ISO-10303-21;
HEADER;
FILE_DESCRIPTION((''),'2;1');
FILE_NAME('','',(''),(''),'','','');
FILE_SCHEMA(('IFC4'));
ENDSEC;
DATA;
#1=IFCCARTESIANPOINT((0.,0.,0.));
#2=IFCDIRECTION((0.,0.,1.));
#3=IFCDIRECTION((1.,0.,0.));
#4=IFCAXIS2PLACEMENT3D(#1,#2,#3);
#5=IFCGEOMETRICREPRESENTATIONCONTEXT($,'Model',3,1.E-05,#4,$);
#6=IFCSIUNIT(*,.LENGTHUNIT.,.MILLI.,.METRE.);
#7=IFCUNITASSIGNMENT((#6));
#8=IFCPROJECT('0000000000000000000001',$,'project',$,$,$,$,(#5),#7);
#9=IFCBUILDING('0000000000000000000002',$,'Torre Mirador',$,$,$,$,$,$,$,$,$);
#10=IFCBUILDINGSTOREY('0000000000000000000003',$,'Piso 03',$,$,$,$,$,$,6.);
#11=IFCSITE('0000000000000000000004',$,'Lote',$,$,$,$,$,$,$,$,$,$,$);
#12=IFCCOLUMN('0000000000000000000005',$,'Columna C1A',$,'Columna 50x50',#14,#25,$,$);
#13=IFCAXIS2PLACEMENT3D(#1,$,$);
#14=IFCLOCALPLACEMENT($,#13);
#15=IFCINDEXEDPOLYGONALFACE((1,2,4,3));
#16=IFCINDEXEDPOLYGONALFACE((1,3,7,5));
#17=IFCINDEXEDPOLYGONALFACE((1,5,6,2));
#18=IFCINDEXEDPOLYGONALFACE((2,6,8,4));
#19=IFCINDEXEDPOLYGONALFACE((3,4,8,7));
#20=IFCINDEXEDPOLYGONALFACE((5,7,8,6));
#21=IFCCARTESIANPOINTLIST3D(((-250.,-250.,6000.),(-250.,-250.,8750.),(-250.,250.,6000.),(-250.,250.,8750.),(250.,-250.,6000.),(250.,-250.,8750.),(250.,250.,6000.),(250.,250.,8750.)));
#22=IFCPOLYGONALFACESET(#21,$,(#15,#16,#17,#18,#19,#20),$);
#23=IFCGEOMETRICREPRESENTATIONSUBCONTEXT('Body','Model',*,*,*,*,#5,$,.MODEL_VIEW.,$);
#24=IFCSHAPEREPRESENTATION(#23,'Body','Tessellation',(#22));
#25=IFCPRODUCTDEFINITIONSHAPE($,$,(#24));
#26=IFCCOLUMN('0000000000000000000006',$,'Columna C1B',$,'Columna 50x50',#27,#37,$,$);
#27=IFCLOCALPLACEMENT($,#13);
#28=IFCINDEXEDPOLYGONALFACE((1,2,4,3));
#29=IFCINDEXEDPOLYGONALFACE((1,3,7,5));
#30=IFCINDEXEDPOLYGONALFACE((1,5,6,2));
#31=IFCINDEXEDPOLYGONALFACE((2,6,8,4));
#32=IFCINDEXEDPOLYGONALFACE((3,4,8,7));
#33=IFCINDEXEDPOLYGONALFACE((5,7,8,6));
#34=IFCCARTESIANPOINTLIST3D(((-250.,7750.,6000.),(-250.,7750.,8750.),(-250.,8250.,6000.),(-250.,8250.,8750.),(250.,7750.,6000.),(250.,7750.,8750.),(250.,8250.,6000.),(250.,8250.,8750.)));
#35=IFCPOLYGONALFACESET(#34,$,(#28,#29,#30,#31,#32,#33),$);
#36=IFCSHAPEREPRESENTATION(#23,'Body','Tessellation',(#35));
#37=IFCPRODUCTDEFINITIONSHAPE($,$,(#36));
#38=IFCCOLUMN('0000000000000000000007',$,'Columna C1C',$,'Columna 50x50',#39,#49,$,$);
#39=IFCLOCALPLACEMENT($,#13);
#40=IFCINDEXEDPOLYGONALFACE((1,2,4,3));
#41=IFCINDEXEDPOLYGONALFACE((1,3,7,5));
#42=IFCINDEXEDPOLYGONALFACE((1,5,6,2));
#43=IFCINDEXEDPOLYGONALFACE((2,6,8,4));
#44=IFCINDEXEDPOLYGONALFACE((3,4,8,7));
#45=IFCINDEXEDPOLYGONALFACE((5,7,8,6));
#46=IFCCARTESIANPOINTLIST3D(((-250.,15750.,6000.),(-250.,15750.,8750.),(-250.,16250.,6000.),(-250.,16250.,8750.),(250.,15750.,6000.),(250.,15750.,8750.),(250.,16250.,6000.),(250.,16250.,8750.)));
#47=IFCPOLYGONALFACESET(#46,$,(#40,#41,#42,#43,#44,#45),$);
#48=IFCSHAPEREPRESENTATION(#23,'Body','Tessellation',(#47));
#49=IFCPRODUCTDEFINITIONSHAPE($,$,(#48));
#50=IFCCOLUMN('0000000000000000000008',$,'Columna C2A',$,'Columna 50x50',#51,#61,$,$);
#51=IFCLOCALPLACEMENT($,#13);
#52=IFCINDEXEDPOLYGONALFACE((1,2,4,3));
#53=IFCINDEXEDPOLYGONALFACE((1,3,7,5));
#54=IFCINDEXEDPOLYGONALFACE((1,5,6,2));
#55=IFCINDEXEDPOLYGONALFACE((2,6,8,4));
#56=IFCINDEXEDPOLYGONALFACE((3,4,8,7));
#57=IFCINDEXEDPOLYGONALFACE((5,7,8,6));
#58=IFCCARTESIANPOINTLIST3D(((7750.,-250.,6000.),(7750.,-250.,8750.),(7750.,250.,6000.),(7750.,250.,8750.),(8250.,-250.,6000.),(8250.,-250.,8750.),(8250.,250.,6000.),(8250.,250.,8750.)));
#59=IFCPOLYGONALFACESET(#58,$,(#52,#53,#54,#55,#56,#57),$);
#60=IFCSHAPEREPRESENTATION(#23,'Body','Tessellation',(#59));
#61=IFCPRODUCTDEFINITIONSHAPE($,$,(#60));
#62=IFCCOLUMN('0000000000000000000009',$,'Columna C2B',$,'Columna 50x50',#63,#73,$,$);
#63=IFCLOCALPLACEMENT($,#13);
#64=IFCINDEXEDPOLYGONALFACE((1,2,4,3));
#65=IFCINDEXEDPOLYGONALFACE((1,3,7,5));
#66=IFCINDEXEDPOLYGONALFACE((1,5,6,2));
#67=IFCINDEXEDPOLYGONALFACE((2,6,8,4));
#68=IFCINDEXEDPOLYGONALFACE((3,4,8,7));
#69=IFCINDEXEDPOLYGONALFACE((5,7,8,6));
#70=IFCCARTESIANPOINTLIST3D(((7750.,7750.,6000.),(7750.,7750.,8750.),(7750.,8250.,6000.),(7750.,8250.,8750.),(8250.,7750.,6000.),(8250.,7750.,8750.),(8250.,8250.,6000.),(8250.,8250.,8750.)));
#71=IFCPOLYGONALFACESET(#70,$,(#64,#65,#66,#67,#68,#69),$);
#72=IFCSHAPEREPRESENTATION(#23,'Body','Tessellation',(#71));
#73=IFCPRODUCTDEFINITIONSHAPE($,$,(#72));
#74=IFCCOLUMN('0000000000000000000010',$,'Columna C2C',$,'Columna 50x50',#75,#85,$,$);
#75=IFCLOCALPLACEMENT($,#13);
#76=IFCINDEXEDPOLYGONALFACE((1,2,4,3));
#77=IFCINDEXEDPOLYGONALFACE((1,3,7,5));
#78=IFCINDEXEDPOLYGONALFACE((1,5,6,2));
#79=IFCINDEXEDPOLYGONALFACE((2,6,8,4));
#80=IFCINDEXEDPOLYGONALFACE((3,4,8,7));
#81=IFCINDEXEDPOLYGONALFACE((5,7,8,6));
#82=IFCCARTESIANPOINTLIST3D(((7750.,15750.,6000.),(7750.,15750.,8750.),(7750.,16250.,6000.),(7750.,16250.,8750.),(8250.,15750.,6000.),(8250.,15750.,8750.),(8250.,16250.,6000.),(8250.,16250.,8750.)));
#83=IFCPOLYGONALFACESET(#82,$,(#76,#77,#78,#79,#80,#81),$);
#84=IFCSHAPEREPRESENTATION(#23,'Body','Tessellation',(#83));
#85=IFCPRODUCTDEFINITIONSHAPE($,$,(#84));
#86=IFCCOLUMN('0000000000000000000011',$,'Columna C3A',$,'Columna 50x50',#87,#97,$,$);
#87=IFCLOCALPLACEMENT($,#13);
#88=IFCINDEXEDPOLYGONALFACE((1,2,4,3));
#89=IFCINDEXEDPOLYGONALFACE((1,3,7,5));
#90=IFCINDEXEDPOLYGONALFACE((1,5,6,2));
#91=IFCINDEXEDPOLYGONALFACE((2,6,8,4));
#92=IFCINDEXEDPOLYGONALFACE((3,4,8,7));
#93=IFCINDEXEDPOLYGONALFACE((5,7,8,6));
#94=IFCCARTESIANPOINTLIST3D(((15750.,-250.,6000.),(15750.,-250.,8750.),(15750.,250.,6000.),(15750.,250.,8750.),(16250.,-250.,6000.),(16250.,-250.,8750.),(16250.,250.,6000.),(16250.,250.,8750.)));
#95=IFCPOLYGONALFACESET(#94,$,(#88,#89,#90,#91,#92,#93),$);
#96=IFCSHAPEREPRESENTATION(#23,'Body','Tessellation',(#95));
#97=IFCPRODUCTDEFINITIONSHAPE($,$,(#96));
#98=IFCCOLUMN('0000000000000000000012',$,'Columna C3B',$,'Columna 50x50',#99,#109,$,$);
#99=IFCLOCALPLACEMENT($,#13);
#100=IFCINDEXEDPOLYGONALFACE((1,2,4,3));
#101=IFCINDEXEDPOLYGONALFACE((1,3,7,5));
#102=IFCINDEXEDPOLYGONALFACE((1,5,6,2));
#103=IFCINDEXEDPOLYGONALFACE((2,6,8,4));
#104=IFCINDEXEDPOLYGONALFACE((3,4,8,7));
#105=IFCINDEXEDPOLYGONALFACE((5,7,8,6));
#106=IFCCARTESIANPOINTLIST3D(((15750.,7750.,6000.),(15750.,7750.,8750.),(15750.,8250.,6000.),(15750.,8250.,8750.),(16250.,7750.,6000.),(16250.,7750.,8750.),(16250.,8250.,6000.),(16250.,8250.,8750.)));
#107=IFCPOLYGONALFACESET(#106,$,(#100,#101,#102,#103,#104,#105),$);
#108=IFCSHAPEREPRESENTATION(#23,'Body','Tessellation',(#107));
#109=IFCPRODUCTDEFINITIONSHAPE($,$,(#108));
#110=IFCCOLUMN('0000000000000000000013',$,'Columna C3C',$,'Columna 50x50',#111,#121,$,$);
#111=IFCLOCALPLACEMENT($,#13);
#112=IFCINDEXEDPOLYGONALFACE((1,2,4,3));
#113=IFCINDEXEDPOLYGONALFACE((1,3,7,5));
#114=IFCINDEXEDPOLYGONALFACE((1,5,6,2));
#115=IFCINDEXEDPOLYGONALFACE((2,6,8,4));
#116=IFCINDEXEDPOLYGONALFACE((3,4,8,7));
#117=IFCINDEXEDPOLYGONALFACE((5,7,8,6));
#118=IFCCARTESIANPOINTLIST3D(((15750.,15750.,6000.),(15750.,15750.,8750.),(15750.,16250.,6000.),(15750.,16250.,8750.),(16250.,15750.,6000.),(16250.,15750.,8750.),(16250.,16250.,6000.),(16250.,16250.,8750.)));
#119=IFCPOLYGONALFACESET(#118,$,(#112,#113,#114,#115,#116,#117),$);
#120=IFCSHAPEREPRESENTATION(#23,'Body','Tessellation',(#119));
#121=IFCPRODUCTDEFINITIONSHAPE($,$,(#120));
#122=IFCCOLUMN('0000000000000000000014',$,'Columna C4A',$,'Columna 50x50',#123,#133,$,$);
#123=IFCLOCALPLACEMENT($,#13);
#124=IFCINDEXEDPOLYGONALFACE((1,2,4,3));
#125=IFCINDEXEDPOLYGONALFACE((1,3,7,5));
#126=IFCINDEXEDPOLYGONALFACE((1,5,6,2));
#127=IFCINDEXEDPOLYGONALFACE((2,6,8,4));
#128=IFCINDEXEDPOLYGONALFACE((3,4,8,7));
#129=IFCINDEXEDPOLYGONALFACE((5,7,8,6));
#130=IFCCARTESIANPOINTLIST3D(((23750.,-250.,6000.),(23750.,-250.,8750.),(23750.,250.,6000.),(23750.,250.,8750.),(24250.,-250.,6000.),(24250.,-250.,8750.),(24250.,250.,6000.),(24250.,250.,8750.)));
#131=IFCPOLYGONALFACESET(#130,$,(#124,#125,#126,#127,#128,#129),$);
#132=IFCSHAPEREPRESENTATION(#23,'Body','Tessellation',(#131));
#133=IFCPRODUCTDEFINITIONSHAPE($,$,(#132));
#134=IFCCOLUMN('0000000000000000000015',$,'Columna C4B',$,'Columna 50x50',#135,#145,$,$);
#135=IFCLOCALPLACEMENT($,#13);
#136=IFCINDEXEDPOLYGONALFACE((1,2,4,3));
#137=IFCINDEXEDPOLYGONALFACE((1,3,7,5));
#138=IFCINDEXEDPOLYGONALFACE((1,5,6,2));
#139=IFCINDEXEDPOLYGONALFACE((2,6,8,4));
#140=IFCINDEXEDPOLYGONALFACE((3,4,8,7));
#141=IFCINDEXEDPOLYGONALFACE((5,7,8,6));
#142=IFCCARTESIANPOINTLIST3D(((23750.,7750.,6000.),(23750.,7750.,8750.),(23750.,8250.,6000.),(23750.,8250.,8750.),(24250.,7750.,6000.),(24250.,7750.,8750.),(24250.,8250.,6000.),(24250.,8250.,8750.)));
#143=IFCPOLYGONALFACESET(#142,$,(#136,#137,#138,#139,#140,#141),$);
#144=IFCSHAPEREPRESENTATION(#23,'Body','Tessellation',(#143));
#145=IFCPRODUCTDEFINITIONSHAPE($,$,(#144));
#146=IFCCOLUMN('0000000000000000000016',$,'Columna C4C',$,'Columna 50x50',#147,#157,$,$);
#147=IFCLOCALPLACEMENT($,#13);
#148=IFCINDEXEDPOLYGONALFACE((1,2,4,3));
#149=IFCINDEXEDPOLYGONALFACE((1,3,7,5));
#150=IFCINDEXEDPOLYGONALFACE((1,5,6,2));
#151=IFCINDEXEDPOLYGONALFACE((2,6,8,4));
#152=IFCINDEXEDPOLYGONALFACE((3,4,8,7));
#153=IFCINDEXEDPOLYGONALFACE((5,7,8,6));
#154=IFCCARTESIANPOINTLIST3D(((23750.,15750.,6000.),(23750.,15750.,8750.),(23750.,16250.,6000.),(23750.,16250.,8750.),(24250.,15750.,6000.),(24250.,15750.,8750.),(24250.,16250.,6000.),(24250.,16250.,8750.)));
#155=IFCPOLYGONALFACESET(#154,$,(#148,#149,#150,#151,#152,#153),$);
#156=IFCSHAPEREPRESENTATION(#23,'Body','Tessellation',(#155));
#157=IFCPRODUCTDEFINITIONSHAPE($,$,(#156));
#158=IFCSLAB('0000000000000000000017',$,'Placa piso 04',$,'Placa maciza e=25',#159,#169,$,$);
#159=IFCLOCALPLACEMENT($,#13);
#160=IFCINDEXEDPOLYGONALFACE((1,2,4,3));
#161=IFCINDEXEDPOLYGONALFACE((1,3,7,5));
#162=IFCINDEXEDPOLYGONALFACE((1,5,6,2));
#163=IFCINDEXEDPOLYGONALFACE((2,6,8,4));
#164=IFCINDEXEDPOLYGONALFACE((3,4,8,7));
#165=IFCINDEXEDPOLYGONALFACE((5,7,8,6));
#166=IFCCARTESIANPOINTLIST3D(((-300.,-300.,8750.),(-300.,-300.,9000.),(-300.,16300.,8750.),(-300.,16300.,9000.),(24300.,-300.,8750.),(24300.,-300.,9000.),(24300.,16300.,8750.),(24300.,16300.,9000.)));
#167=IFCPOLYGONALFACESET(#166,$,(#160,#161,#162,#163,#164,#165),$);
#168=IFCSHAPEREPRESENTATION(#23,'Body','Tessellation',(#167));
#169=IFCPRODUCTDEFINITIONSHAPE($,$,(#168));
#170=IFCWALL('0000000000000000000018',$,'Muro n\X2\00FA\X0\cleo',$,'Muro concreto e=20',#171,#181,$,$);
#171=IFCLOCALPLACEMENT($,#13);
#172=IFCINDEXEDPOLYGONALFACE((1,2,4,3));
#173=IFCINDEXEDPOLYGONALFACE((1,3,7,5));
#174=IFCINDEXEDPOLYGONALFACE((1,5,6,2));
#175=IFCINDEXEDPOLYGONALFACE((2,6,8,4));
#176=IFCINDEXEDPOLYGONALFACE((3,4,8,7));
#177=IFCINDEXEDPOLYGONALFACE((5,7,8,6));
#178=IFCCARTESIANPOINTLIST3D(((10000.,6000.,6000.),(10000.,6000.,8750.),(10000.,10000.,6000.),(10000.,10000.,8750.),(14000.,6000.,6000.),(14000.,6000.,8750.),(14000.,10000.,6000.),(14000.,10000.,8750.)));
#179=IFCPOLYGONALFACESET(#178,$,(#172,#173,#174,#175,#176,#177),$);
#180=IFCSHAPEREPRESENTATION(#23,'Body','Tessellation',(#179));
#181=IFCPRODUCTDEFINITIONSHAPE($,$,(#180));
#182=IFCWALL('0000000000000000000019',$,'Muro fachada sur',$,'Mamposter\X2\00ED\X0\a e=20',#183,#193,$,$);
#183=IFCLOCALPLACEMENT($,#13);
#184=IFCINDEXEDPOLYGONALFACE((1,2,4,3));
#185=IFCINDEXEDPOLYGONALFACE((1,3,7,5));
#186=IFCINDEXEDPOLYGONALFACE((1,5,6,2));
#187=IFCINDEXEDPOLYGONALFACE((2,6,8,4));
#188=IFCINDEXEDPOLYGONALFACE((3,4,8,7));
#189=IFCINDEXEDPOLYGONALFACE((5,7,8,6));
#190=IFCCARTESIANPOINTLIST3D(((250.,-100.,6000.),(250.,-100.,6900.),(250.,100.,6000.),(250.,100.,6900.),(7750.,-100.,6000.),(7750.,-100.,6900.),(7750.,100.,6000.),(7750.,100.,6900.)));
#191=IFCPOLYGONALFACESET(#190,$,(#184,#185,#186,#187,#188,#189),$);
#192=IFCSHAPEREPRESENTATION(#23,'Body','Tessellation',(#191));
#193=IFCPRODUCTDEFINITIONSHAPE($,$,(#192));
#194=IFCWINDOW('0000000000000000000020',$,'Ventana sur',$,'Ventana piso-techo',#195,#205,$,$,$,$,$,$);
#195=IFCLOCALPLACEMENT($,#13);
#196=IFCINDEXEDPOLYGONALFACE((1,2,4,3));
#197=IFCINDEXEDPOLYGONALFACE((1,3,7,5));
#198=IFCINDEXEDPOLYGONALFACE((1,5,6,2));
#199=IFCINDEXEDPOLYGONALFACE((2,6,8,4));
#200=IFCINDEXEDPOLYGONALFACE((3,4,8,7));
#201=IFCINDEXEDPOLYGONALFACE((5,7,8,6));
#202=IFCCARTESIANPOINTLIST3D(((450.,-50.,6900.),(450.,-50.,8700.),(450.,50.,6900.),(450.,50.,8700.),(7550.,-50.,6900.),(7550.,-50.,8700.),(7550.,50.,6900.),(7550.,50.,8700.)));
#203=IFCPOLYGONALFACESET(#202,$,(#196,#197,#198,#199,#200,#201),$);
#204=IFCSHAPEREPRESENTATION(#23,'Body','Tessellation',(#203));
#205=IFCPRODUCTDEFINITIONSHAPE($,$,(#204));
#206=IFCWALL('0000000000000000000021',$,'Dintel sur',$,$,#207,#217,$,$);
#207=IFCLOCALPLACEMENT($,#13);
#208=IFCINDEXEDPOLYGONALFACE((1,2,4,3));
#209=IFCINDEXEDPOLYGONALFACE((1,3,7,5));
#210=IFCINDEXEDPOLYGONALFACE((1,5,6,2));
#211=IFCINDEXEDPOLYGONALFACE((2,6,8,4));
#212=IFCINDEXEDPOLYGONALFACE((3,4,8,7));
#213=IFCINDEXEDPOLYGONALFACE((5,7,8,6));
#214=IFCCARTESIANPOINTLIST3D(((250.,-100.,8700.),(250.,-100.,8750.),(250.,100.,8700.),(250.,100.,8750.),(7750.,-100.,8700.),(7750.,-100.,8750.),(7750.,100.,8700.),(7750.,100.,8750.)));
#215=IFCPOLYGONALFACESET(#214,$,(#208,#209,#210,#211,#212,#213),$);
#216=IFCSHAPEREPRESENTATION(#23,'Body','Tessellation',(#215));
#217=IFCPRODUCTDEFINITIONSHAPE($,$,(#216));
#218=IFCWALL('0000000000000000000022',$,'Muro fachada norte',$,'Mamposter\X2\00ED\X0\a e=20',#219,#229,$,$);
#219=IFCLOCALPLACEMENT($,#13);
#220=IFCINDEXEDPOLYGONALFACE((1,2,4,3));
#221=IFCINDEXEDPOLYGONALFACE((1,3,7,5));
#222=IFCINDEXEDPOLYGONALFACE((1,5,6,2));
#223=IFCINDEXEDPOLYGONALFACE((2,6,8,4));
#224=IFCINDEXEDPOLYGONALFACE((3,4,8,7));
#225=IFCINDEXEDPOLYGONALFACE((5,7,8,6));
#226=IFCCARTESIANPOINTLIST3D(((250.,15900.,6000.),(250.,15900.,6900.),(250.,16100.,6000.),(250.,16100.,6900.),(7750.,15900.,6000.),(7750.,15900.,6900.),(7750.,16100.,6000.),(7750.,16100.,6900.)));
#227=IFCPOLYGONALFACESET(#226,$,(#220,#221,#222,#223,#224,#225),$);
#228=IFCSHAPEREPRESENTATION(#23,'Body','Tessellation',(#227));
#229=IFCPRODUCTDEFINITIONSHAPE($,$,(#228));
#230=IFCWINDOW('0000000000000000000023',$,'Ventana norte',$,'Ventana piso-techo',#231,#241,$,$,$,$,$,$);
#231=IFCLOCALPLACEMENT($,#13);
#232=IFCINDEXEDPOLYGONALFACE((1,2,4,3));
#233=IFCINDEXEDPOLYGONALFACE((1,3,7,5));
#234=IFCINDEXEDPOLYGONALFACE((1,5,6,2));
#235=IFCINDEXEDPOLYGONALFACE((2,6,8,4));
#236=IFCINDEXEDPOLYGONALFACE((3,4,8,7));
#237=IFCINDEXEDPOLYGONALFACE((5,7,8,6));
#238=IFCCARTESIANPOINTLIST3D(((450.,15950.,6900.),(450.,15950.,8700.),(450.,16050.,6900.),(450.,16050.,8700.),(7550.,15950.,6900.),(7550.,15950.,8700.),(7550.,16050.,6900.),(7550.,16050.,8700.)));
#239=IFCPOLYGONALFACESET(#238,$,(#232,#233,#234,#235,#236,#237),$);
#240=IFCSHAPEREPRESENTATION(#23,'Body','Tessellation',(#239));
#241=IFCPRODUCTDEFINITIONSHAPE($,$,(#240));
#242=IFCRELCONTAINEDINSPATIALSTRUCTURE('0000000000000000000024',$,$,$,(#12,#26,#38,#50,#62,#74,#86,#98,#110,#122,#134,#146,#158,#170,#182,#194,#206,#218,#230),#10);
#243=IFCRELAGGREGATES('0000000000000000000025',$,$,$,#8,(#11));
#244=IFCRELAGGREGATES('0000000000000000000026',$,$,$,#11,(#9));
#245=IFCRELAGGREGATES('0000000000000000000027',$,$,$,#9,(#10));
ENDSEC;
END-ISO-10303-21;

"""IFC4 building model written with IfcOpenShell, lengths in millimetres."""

from ifc_helpers import new_model, si_unit, frame, origin_with_axes, place, context, subcontext, project, spatial, indexed_curve, outline, extrude, element, save


model = new_model("IFC4")

# Units and contexts
model_context = context("Model", 3, precision=1e-05, world=origin_with_axes())
body_context = subcontext(model_context, "Body", "Model", "MODEL_VIEW")
ifc_project = project(units=[si_unit("LENGTHUNIT", "METRE", prefix="MILLI")], contexts=[model_context])

# Site, building, storey
site = spatial("IfcSite", under=ifc_project, Name="Lote")
building = spatial("IfcBuilding", under=site, Name="Torre Mirador")
storey = spatial("IfcBuildingStorey", under=building, Name="Piso 03", Elevation=6.0)

# Columns
for number, where, z_axis, x_axis, name in (
    (1, (-250.0, -250.0, 6000.0), (0.0, 0.0, 1.0), (1.0, 0.0, 0.0), "Columna C1A"),
    (2, (-250.0, 7750.0, 6000.0), (0.0, 0.0, 1.0), (1.0, 0.0, 0.0), "Columna C1B"),
    (3, (-250.0, 15750.0, 6000.0), (0.0, 0.0, 1.0), (1.0, 0.0, 0.0), "Columna C1C"),
    (4, (7750.0, -250.0, 6000.0), (0.0, 0.0, 1.0), (1.0, 0.0, 0.0), "Columna C2A"),
    (5, (7750.0, 7750.0, 6000.0), (0.0, 0.0, 1.0), (1.0, 0.0, 0.0), "Columna C2B"),
    (6, (7750.0, 15750.0, 6000.0), (0.0, 0.0, 1.0), (1.0, 0.0, 0.0), "Columna C2C"),
    (7, (15750.0, -250.0, 6000.0), (0.0, 0.0, 1.0), (1.0, 0.0, 0.0), "Columna C3A"),
    (8, (15750.0, 7750.0, 6000.0), (0.0, 0.0, 1.0), (1.0, 0.0, 0.0), "Columna C3B"),
    (9, (15750.0, 15750.0, 6000.0), (0.0, 0.0, 1.0), (1.0, 0.0, 0.0), "Columna C3C"),
    (10, (23750.0, -250.0, 6000.0), (0.0, 0.0, 1.0), (1.0, 0.0, 0.0), "Columna C4A"),
    (11, (23750.0, 7750.0, 6000.0), (0.0, 0.0, 1.0), (1.0, 0.0, 0.0), "Columna C4B"),
    (12, (23750.0, 15750.0, 6000.0), (0.0, 0.0, 1.0), (1.0, 0.0, 0.0), "Columna C4C"),
):
    element("IfcColumn", number, at=place(None, frame(where, z_axis=z_axis, x_axis=x_axis)), inside=storey, Name=name, ObjectType="Columna 50x50", context=body_context, shape_type="SweptSolid", body=[
        extrude(outline(indexed_curve([(0.0, 0.0), (0.0, 500.0), (500.0, 500.0), (500.0, 0.0), (0.0, 0.0)], self_intersect=False)), origin_with_axes(), (0.0, 0.0, 1.0), 2750.0),
    ])

# Slab
slab_placement = place(None, frame((-300.0, -300.0, 8750.0), z_axis=(0.0, 0.0, 1.0), x_axis=(1.0, 0.0, 0.0)))
element("IfcSlab", 13, at=slab_placement, inside=storey, Name="Placa piso 04", ObjectType="Placa maciza e=25", context=body_context, shape_type="SweptSolid", body=[
    extrude(outline(indexed_curve([(0.0, 0.0), (0.0, 16600.0), (24600.0, 16600.0), (24600.0, 0.0), (0.0, 0.0)], self_intersect=False)), origin_with_axes(), (0.0, 0.0, 1.0), 250.0),
])

# Walls
wall_1_placement = place(None, frame((10000.0, 6000.0, 6000.0), z_axis=(0.0, 0.0, 1.0), x_axis=(1.0, 0.0, 0.0)))
element("IfcWall", 14, at=wall_1_placement, inside=storey, Name="Muro núcleo", ObjectType="Muro concreto e=20", context=body_context, shape_type="SweptSolid", body=[
    extrude(outline(indexed_curve([(0.0, 0.0), (0.0, 4000.0), (4000.0, 4000.0), (4000.0, 0.0), (0.0, 0.0)], self_intersect=False)), origin_with_axes(), (0.0, 0.0, 1.0), 2750.0),
])
wall_2_placement = place(None, frame((250.0, -100.0, 6000.0), z_axis=(0.0, 0.0, 1.0), x_axis=(1.0, 0.0, 0.0)))
element("IfcWall", 15, at=wall_2_placement, inside=storey, Name="Muro fachada sur", ObjectType="Mampostería e=20", context=body_context, shape_type="SweptSolid", body=[
    extrude(outline(indexed_curve([(0.0, 0.0), (0.0, 200.0), (7500.0, 200.0), (7500.0, 0.0), (0.0, 0.0)], self_intersect=False)), origin_with_axes(), (0.0, 0.0, 1.0), 900.0),
])

# Window
window_1_placement = place(None, frame((450.0, -50.0, 6900.0), z_axis=(0.0, 0.0, 1.0), x_axis=(1.0, 0.0, 0.0)))
element("IfcWindow", 16, at=window_1_placement, inside=storey, Name="Ventana sur", ObjectType="Ventana piso-techo", context=body_context, shape_type="SweptSolid", body=[
    extrude(outline(indexed_curve([(0.0, 0.0), (0.0, 100.0), (7100.0, 100.0), (7100.0, 0.0), (0.0, 0.0)], self_intersect=False)), origin_with_axes(), (0.0, 0.0, 1.0), 1800.0),
])

# Walls
wall_3_placement = place(None, frame((250.0, -100.0, 8700.0), z_axis=(0.0, 0.0, 1.0), x_axis=(1.0, 0.0, 0.0)))
element("IfcWall", 17, at=wall_3_placement, inside=storey, Name="Dintel sur", context=body_context, shape_type="SweptSolid", body=[
    extrude(outline(indexed_curve([(0.0, 0.0), (0.0, 200.0), (7500.0, 200.0), (7500.0, 0.0), (0.0, 0.0)], self_intersect=False)), origin_with_axes(), (0.0, 0.0, 1.0), 50.0),
])
wall_4_placement = place(None, frame((250.0, 15900.0, 6000.0), z_axis=(0.0, 0.0, 1.0), x_axis=(1.0, 0.0, 0.0)))
element("IfcWall", 18, at=wall_4_placement, inside=storey, Name="Muro fachada norte", ObjectType="Mampostería e=20", context=body_context, shape_type="SweptSolid", body=[
    extrude(outline(indexed_curve([(0.0, 0.0), (0.0, 200.0), (7500.0, 200.0), (7500.0, 0.0), (0.0, 0.0)], self_intersect=False)), origin_with_axes(), (0.0, 0.0, 1.0), 900.0),
])

# Window
window_2_placement = place(None, frame((450.0, 15950.0, 6900.0), z_axis=(0.0, 0.0, 1.0), x_axis=(1.0, 0.0, 0.0)))
element("IfcWindow", 19, at=window_2_placement, inside=storey, Name="Ventana norte", ObjectType="Ventana piso-techo", context=body_context, shape_type="SweptSolid", body=[
    extrude(outline(indexed_curve([(0.0, 0.0), (0.0, 100.0), (7100.0, 100.0), (7100.0, 0.0), (0.0, 0.0)], self_intersect=False)), origin_with_axes(), (0.0, 0.0, 1.0), 1800.0),
])

save(model, "model.ifc")
